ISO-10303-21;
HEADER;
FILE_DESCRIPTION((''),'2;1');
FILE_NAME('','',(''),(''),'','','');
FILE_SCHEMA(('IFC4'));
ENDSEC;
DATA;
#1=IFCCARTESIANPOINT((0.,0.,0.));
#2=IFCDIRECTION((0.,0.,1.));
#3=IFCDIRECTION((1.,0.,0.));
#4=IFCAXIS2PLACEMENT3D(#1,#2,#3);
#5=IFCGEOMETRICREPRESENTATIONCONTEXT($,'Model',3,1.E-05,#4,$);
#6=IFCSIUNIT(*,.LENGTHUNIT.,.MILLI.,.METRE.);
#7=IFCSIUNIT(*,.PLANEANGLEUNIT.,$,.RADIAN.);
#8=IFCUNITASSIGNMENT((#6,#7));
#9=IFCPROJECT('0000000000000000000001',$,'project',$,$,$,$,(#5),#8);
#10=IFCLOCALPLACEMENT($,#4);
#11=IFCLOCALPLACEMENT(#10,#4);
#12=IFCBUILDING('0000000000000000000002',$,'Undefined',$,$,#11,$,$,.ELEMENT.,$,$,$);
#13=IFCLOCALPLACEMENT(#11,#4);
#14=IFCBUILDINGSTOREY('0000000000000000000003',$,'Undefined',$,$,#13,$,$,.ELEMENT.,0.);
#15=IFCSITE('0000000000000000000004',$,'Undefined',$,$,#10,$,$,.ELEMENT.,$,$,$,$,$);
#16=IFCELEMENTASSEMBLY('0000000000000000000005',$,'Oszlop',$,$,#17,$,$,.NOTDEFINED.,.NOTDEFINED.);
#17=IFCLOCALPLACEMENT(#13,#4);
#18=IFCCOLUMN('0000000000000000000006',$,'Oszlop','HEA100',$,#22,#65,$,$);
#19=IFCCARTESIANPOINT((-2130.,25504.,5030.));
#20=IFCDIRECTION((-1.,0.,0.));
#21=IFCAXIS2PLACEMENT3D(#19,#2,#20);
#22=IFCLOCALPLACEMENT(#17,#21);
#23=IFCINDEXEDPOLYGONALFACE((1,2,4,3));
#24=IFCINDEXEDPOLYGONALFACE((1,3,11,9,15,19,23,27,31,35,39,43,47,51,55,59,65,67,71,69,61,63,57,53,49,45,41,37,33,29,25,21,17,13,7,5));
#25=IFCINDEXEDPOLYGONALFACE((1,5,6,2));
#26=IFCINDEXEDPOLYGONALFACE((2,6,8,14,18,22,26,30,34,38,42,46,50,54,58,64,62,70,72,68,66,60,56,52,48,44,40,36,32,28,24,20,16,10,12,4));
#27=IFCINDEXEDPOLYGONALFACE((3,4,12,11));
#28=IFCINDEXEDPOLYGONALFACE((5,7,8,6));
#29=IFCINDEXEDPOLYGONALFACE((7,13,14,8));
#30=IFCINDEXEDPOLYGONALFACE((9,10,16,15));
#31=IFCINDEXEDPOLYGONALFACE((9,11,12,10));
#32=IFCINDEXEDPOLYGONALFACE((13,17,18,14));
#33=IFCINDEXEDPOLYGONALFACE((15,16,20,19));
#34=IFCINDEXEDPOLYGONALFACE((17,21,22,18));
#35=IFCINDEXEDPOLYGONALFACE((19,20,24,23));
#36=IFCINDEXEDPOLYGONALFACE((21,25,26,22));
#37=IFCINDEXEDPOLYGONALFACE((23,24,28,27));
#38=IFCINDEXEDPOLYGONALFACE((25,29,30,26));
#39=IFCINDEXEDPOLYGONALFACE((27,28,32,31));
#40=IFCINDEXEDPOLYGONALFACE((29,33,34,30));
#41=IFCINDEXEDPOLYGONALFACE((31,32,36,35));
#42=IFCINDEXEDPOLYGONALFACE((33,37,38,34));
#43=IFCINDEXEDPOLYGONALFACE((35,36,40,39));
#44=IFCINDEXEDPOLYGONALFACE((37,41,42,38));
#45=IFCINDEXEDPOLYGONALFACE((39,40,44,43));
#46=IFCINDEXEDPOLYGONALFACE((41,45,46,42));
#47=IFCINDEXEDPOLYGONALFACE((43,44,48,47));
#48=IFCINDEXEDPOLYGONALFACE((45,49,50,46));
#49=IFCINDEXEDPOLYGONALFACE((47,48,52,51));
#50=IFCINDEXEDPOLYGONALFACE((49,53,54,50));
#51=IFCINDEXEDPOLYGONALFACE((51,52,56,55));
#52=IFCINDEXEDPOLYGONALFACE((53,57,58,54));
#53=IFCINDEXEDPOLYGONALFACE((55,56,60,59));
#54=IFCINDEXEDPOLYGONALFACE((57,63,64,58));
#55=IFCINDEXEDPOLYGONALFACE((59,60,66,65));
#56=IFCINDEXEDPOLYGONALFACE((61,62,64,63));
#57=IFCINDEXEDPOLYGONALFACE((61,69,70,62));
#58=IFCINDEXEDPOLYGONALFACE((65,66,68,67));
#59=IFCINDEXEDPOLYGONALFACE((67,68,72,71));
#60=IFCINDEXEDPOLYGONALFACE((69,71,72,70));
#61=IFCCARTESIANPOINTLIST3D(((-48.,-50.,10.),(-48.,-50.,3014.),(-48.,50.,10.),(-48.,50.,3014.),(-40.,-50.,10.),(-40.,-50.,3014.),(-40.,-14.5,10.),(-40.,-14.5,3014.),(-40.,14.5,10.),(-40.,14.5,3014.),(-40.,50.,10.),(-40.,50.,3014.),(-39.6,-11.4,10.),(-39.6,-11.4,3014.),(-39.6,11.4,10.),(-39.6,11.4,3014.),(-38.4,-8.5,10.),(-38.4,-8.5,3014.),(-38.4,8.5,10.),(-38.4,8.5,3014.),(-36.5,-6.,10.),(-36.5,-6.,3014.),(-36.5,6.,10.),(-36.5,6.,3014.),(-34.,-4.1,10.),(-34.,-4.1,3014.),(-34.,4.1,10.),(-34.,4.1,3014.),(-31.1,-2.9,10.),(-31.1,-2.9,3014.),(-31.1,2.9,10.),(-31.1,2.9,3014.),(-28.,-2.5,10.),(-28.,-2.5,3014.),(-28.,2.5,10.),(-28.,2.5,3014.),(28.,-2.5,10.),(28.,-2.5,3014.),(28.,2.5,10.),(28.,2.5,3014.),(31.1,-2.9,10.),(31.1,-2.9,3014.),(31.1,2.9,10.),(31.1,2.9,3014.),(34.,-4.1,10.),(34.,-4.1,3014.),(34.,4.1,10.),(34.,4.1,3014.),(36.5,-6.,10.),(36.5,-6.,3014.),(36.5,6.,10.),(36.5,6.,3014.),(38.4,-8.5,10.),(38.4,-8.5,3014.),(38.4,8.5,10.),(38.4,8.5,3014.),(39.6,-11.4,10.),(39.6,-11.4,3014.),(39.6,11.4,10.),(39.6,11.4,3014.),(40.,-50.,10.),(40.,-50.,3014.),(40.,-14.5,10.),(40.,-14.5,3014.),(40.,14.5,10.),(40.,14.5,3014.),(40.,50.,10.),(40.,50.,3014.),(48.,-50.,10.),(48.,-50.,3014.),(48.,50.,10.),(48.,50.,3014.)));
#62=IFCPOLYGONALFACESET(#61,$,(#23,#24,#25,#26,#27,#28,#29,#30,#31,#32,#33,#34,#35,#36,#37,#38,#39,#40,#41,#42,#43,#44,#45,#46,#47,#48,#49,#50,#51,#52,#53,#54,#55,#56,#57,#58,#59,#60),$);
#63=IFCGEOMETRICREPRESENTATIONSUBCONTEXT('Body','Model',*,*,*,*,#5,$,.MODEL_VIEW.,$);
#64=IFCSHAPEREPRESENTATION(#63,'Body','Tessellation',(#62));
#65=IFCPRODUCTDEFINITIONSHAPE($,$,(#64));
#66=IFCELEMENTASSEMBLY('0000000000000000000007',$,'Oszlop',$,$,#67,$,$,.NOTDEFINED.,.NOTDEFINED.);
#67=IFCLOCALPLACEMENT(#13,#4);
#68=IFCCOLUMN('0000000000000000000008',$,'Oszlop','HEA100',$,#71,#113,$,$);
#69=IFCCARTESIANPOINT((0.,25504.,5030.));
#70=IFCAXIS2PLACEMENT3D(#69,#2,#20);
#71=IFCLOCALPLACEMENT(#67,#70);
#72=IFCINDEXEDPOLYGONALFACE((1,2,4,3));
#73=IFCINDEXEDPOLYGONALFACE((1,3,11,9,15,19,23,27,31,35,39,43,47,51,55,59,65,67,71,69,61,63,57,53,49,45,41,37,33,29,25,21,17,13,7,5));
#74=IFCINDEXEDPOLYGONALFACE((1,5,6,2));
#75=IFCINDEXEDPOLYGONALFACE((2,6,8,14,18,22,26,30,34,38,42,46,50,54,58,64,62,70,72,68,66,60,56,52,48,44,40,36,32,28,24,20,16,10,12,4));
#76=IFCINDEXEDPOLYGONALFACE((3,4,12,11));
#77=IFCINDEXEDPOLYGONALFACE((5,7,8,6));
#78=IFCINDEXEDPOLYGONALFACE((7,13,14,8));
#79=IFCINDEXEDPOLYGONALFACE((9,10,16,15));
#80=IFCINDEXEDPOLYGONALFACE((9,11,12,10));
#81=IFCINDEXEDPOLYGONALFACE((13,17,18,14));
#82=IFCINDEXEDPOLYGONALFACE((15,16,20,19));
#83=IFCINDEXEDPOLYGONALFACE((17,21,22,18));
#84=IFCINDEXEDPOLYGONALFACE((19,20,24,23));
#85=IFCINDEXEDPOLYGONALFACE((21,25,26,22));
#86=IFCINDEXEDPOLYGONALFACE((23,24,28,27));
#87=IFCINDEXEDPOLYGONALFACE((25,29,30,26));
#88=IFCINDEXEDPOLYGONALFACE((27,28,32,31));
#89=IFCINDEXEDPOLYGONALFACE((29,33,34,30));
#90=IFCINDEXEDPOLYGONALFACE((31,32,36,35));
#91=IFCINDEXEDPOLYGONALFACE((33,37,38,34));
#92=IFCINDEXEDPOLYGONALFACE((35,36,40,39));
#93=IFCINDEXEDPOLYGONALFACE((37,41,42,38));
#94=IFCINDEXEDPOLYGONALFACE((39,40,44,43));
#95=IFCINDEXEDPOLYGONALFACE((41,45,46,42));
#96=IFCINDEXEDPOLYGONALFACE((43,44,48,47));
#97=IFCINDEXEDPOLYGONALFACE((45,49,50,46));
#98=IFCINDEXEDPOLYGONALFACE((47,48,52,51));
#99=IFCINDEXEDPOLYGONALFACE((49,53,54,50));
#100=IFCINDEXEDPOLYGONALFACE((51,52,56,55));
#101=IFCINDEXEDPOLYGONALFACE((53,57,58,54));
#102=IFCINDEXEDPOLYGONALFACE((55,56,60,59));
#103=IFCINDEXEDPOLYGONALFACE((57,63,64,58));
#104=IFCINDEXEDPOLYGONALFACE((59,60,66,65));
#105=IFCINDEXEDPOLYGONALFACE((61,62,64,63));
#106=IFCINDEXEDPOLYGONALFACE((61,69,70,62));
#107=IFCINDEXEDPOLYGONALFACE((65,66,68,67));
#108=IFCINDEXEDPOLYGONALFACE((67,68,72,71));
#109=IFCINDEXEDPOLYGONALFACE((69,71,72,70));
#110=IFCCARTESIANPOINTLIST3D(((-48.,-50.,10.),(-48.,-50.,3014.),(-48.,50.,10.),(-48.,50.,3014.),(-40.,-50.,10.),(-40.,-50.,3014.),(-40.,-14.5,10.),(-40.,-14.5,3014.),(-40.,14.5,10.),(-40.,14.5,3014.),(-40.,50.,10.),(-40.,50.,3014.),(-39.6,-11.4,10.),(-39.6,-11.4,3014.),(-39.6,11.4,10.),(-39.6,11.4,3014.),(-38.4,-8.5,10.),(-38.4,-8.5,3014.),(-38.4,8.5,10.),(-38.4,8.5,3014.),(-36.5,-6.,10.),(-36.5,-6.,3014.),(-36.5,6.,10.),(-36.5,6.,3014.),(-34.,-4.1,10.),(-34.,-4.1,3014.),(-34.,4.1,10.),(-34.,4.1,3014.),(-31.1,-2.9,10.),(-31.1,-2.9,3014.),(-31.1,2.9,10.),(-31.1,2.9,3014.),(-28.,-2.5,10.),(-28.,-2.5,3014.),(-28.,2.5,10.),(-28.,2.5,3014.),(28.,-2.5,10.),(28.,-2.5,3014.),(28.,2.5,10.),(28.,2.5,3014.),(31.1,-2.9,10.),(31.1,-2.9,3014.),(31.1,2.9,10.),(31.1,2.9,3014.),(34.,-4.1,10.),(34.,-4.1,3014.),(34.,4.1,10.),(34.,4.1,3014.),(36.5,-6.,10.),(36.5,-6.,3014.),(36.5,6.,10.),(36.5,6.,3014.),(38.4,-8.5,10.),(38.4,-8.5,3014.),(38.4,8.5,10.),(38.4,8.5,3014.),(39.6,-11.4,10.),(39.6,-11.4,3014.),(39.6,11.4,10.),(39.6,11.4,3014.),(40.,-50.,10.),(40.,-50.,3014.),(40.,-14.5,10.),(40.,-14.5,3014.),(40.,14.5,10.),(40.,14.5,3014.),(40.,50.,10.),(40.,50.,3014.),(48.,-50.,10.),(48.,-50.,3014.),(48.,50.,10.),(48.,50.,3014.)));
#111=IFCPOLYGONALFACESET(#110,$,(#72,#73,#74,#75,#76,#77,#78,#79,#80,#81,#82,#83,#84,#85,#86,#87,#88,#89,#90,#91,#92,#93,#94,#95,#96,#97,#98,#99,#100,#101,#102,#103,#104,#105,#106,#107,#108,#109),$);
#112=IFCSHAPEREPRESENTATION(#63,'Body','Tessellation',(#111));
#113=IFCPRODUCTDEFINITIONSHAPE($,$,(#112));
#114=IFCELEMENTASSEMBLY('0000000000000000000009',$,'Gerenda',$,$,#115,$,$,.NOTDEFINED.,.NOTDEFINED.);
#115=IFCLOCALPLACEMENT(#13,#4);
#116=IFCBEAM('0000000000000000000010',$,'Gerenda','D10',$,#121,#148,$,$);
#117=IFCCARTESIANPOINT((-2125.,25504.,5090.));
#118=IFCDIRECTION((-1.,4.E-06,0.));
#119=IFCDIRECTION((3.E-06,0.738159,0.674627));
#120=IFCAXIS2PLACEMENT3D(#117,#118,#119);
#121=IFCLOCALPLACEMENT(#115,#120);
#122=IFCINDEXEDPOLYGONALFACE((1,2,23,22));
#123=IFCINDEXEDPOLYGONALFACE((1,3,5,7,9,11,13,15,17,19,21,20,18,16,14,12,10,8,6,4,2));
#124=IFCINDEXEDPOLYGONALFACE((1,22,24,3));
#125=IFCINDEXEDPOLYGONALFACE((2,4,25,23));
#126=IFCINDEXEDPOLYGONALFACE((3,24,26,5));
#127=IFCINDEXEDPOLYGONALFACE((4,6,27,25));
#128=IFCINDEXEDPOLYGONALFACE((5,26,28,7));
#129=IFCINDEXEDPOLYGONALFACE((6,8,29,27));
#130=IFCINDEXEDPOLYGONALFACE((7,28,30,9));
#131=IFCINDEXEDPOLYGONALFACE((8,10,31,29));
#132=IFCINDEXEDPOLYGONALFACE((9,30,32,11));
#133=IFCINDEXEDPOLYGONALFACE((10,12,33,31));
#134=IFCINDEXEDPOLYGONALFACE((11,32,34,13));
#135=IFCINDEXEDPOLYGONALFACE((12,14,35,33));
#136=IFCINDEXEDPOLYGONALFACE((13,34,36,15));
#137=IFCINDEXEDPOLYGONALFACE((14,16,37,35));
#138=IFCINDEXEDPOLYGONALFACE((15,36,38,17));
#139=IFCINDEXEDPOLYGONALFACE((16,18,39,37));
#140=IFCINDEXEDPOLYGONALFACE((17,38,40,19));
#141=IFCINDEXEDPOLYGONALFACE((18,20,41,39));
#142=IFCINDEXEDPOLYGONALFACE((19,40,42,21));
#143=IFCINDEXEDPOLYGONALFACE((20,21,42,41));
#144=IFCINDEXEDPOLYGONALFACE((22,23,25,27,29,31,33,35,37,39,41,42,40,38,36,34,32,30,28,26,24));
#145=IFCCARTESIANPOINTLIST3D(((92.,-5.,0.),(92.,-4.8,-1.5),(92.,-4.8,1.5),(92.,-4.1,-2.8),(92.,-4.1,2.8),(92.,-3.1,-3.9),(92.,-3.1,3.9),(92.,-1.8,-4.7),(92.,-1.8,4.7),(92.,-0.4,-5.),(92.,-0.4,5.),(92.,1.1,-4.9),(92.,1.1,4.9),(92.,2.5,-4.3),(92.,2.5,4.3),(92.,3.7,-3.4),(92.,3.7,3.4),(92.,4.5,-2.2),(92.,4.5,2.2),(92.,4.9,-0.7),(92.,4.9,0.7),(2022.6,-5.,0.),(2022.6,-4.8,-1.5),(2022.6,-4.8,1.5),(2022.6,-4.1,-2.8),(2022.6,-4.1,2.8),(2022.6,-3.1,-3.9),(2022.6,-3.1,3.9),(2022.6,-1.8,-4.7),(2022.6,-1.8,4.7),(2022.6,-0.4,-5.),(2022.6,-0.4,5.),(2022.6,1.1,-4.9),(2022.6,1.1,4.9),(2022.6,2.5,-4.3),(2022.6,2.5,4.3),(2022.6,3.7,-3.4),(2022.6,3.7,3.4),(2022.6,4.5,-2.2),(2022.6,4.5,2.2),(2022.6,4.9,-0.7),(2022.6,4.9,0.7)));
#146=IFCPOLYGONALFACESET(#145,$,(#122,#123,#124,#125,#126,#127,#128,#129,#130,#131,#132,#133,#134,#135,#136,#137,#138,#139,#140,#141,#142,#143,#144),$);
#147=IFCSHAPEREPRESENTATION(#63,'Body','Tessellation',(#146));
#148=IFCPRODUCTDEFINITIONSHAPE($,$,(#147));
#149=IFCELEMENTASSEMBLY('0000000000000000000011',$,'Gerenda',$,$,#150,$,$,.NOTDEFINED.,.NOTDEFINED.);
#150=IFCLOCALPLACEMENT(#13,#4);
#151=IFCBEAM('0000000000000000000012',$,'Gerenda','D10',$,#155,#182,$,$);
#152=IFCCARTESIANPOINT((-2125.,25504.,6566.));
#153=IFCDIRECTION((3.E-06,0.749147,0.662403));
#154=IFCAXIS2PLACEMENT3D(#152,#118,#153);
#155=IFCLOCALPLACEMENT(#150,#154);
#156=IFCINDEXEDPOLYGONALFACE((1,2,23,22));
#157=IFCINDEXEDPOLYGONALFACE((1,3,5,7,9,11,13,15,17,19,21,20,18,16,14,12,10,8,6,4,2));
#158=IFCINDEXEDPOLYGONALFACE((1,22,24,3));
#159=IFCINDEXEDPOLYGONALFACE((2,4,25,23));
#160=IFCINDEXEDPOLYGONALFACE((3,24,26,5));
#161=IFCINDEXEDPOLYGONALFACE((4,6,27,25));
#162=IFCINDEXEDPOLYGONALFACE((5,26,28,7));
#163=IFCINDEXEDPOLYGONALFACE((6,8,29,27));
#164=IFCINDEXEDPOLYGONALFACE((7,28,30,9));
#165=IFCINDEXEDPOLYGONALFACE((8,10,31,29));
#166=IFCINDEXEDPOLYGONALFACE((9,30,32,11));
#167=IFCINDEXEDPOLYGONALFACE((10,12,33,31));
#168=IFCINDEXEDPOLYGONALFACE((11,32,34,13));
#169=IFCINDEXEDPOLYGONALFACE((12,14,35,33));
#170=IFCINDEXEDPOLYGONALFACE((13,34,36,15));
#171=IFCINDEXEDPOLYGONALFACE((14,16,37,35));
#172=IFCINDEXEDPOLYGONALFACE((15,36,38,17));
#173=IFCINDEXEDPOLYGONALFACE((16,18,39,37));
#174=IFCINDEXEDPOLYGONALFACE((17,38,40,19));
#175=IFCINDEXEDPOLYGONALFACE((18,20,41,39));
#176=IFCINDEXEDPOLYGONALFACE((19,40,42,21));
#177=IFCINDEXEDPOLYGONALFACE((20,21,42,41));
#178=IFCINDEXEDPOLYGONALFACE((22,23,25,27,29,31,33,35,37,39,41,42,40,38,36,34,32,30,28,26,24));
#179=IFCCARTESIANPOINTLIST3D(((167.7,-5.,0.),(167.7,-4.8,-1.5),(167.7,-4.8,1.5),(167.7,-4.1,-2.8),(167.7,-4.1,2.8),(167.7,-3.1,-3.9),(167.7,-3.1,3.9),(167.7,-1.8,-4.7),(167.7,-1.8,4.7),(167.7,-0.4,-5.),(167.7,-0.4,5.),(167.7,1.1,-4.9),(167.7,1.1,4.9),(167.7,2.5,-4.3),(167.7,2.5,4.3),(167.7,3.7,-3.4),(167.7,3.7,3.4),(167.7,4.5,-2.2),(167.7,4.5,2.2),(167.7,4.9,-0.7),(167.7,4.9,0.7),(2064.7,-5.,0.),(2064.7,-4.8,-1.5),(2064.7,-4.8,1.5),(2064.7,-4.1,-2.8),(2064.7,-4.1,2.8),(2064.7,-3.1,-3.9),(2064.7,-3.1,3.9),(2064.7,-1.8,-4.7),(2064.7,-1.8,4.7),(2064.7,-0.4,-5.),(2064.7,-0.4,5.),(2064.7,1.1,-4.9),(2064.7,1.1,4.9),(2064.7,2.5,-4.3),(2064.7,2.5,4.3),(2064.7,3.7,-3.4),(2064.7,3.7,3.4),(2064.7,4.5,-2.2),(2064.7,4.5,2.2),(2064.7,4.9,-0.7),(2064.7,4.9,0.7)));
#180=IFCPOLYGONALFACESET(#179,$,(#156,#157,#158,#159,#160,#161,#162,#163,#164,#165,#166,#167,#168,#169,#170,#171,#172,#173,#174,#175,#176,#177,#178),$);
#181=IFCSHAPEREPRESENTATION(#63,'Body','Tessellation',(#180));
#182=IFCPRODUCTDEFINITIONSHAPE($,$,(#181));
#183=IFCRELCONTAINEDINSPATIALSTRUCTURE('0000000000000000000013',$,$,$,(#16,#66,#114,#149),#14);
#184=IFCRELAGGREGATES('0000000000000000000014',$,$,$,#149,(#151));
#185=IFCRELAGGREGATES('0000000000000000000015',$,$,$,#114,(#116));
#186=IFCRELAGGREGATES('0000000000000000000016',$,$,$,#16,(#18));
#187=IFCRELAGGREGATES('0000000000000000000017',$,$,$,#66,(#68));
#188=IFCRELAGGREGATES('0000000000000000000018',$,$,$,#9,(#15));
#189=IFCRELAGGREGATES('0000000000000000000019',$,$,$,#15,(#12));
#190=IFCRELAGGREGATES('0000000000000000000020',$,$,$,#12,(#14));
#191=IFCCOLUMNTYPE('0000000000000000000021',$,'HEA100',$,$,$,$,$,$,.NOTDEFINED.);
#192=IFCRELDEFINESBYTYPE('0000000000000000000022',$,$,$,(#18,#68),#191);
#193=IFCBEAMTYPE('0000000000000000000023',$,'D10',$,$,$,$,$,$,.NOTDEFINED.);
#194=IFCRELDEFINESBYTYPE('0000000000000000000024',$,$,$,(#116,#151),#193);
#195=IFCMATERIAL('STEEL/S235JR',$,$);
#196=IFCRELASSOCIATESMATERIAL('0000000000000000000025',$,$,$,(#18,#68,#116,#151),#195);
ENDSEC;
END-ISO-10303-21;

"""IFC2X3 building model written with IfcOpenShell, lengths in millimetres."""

from ifc_helpers import new_model, si_unit, frame, origin_with_axes, origin_2d_with_axis, place, context, subcontext, project, spatial, circle, i_section, extrude, clip, halfspace, material, type_object, element, aggregate, save


model = new_model("IFC2X3")

# Units and contexts
model_context = context("Model", 3, precision=1e-05, world=origin_with_axes())
body_context = subcontext(model_context, "Body", "Model", "MODEL_VIEW")
ifc_project = project(units=[si_unit("LENGTHUNIT", "METRE", prefix="MILLI"), si_unit("PLANEANGLEUNIT", "RADIAN")], contexts=[model_context])

# Site, building, storey
site_placement = place(None, origin_with_axes())
site = spatial("IfcSite", under=ifc_project, at=site_placement, Name="Undefined", CompositionType="ELEMENT")
building_placement = place(site_placement, origin_with_axes())
building = spatial("IfcBuilding", under=site, at=building_placement, Name="Undefined", CompositionType="ELEMENT")
storey_placement = place(building_placement, origin_with_axes())
storey = spatial("IfcBuildingStorey", under=building, at=storey_placement, Name="Undefined", CompositionType="ELEMENT", Elevation=0.0)

# Element assemblies, columns
assembly_1_placement = place(storey_placement, origin_with_axes())
assembly_1 = element("IfcElementAssembly", 1, at=assembly_1_placement, inside=storey, Name="Oszlop", AssemblyPlace="NOTDEFINED", PredefinedType="NOTDEFINED")
ifc_material_1 = material(Name="STEEL/S235JR")
column_type = type_object("IfcColumnType", Name="HEA100", PredefinedType="NOTDEFINED")
column_1_placement = place(assembly_1_placement, frame((-2130.0, 25504.0, 5030.0), z_axis=(0.0, 0.0, 1.0), x_axis=(-1.0, 0.0, 0.0)))
column_1 = element("IfcColumn", 2, at=column_1_placement, type_object=column_type, material=ifc_material_1, Name="Oszlop", Description="HEA100", context=body_context, shape_type="Clipping", body=[
    clip(clip(extrude(i_section(OverallWidth=100.0, OverallDepth=96.0, WebThickness=5.0, FlangeThickness=8.0, FilletRadius=12.0, at=origin_2d_with_axis()), frame((0.0, 0.0, 3024.0), z_axis=(0.0, 0.0, -1.0), x_axis=(0.0, 1.0, 0.0)), (0.0, 0.0, 1.0), 3024.0), halfspace(frame((-48.0, 0.0, 3014.0), z_axis=(0.0, 0.0, -1.0), x_axis=(0.0, -1.0, 0.0)), True)), halfspace(frame((-48.0, 0.0, 10.0), z_axis=(0.0, 0.0, 1.0), x_axis=(0.0, 1.0, 0.0)), True)),
])
assembly_2_placement = place(storey_placement, origin_with_axes())
assembly_2 = element("IfcElementAssembly", 3, at=assembly_2_placement, inside=storey, Name="Oszlop", AssemblyPlace="NOTDEFINED", PredefinedType="NOTDEFINED")
column_2_placement = place(assembly_2_placement, frame((0.0, 25504.0, 5030.0), z_axis=(0.0, 0.0, 1.0), x_axis=(-1.0, 0.0, 0.0)))
column_2 = element("IfcColumn", 4, at=column_2_placement, type_object=column_type, material=ifc_material_1, Name="Oszlop", Description="HEA100", context=body_context, shape_type="Clipping", body=[
    clip(clip(extrude(i_section(OverallWidth=100.0, OverallDepth=96.0, WebThickness=5.0, FlangeThickness=8.0, FilletRadius=12.0, at=origin_2d_with_axis()), frame((0.0, 0.0, 3024.0), z_axis=(0.0, 0.0, -1.0), x_axis=(0.0, 1.0, 0.0)), (0.0, 0.0, 1.0), 3024.0), halfspace(frame((-48.0, 0.0, 3014.0), z_axis=(0.0, 0.0, -1.0), x_axis=(0.0, -1.0, 0.0)), True)), halfspace(frame((-48.0, 0.0, 10.0), z_axis=(0.0, 0.0, 1.0), x_axis=(0.0, 1.0, 0.0)), True)),
])

# Element assemblies, beams
assembly_3_placement = place(storey_placement, origin_with_axes())
assembly_3 = element("IfcElementAssembly", 5, at=assembly_3_placement, inside=storey, Name="Gerenda", AssemblyPlace="NOTDEFINED", PredefinedType="NOTDEFINED")
beam_type_1 = type_object("IfcBeamType", Name="D10", PredefinedType="NOTDEFINED")
beam_1_placement = place(assembly_3_placement, frame((-2125.0, 25504.0, 5090.0), z_axis=(-1.0, 0.000004, 0.0), x_axis=(0.000003, 0.738159, 0.674627)))
beam_1 = element("IfcBeam", 6, at=beam_1_placement, type_object=beam_type_1, material=ifc_material_1, Name="Gerenda", Description="D10", context=body_context, shape_type="Clipping", body=[
    clip(clip(extrude(circle(Radius=5.0, at=origin_2d_with_axis()), frame((2187.9, 0.0, 0.0), z_axis=(-1.0, 0.0, 0.0), x_axis=(0.0, -1.0, 0.0)), (0.0, 0.0, 1.0), 2187.9), halfspace(frame((2022.6, 0.0, 7.5), z_axis=(-1.0, 0.0, 0.0), x_axis=(0.0, -1.0, -0.000003)), True)), halfspace(frame((92.0, 0.0, 7.5), z_axis=(1.0, 0.0, 0.0), x_axis=(0.0, 1.0, 0.0)), True)),
])
assembly_4_placement = place(storey_placement, origin_with_axes())
assembly_4 = element("IfcElementAssembly", 7, at=assembly_4_placement, inside=storey, Name="Gerenda", AssemblyPlace="NOTDEFINED", PredefinedType="NOTDEFINED")
beam_2_placement = place(assembly_4_placement, frame((-2125.0, 25504.0, 6566.0), z_axis=(-1.0, 0.000004, 0.0), x_axis=(0.000003, 0.749147, 0.662403)))
beam_2 = element("IfcBeam", 8, at=beam_2_placement, type_object=beam_type_1, material=ifc_material_1, Name="Gerenda", Description="D10", context=body_context, shape_type="Clipping", body=[
    clip(clip(extrude(circle(Radius=5.0, at=origin_2d_with_axis()), frame((2155.8, 0.0, 0.0), z_axis=(-1.0, 0.0, 0.0), x_axis=(0.0, -1.0, 0.0)), (0.0, 0.0, 1.0), 2155.8), halfspace(frame((2064.7, 0.0, 7.5), z_axis=(-1.0, 0.0, 0.0), x_axis=(0.0, -1.0, 0.0)), True)), halfspace(frame((167.7, 0.0, 7.5), z_axis=(1.0, 0.0, 0.0), x_axis=(0.0, 1.0, 0.000003)), True)),
])
aggregate(assembly_4, [beam_2])

aggregate(assembly_3, [beam_1])
aggregate(assembly_1, [column_1])
aggregate(assembly_2, [column_2])

save(model, "model.ifc")
